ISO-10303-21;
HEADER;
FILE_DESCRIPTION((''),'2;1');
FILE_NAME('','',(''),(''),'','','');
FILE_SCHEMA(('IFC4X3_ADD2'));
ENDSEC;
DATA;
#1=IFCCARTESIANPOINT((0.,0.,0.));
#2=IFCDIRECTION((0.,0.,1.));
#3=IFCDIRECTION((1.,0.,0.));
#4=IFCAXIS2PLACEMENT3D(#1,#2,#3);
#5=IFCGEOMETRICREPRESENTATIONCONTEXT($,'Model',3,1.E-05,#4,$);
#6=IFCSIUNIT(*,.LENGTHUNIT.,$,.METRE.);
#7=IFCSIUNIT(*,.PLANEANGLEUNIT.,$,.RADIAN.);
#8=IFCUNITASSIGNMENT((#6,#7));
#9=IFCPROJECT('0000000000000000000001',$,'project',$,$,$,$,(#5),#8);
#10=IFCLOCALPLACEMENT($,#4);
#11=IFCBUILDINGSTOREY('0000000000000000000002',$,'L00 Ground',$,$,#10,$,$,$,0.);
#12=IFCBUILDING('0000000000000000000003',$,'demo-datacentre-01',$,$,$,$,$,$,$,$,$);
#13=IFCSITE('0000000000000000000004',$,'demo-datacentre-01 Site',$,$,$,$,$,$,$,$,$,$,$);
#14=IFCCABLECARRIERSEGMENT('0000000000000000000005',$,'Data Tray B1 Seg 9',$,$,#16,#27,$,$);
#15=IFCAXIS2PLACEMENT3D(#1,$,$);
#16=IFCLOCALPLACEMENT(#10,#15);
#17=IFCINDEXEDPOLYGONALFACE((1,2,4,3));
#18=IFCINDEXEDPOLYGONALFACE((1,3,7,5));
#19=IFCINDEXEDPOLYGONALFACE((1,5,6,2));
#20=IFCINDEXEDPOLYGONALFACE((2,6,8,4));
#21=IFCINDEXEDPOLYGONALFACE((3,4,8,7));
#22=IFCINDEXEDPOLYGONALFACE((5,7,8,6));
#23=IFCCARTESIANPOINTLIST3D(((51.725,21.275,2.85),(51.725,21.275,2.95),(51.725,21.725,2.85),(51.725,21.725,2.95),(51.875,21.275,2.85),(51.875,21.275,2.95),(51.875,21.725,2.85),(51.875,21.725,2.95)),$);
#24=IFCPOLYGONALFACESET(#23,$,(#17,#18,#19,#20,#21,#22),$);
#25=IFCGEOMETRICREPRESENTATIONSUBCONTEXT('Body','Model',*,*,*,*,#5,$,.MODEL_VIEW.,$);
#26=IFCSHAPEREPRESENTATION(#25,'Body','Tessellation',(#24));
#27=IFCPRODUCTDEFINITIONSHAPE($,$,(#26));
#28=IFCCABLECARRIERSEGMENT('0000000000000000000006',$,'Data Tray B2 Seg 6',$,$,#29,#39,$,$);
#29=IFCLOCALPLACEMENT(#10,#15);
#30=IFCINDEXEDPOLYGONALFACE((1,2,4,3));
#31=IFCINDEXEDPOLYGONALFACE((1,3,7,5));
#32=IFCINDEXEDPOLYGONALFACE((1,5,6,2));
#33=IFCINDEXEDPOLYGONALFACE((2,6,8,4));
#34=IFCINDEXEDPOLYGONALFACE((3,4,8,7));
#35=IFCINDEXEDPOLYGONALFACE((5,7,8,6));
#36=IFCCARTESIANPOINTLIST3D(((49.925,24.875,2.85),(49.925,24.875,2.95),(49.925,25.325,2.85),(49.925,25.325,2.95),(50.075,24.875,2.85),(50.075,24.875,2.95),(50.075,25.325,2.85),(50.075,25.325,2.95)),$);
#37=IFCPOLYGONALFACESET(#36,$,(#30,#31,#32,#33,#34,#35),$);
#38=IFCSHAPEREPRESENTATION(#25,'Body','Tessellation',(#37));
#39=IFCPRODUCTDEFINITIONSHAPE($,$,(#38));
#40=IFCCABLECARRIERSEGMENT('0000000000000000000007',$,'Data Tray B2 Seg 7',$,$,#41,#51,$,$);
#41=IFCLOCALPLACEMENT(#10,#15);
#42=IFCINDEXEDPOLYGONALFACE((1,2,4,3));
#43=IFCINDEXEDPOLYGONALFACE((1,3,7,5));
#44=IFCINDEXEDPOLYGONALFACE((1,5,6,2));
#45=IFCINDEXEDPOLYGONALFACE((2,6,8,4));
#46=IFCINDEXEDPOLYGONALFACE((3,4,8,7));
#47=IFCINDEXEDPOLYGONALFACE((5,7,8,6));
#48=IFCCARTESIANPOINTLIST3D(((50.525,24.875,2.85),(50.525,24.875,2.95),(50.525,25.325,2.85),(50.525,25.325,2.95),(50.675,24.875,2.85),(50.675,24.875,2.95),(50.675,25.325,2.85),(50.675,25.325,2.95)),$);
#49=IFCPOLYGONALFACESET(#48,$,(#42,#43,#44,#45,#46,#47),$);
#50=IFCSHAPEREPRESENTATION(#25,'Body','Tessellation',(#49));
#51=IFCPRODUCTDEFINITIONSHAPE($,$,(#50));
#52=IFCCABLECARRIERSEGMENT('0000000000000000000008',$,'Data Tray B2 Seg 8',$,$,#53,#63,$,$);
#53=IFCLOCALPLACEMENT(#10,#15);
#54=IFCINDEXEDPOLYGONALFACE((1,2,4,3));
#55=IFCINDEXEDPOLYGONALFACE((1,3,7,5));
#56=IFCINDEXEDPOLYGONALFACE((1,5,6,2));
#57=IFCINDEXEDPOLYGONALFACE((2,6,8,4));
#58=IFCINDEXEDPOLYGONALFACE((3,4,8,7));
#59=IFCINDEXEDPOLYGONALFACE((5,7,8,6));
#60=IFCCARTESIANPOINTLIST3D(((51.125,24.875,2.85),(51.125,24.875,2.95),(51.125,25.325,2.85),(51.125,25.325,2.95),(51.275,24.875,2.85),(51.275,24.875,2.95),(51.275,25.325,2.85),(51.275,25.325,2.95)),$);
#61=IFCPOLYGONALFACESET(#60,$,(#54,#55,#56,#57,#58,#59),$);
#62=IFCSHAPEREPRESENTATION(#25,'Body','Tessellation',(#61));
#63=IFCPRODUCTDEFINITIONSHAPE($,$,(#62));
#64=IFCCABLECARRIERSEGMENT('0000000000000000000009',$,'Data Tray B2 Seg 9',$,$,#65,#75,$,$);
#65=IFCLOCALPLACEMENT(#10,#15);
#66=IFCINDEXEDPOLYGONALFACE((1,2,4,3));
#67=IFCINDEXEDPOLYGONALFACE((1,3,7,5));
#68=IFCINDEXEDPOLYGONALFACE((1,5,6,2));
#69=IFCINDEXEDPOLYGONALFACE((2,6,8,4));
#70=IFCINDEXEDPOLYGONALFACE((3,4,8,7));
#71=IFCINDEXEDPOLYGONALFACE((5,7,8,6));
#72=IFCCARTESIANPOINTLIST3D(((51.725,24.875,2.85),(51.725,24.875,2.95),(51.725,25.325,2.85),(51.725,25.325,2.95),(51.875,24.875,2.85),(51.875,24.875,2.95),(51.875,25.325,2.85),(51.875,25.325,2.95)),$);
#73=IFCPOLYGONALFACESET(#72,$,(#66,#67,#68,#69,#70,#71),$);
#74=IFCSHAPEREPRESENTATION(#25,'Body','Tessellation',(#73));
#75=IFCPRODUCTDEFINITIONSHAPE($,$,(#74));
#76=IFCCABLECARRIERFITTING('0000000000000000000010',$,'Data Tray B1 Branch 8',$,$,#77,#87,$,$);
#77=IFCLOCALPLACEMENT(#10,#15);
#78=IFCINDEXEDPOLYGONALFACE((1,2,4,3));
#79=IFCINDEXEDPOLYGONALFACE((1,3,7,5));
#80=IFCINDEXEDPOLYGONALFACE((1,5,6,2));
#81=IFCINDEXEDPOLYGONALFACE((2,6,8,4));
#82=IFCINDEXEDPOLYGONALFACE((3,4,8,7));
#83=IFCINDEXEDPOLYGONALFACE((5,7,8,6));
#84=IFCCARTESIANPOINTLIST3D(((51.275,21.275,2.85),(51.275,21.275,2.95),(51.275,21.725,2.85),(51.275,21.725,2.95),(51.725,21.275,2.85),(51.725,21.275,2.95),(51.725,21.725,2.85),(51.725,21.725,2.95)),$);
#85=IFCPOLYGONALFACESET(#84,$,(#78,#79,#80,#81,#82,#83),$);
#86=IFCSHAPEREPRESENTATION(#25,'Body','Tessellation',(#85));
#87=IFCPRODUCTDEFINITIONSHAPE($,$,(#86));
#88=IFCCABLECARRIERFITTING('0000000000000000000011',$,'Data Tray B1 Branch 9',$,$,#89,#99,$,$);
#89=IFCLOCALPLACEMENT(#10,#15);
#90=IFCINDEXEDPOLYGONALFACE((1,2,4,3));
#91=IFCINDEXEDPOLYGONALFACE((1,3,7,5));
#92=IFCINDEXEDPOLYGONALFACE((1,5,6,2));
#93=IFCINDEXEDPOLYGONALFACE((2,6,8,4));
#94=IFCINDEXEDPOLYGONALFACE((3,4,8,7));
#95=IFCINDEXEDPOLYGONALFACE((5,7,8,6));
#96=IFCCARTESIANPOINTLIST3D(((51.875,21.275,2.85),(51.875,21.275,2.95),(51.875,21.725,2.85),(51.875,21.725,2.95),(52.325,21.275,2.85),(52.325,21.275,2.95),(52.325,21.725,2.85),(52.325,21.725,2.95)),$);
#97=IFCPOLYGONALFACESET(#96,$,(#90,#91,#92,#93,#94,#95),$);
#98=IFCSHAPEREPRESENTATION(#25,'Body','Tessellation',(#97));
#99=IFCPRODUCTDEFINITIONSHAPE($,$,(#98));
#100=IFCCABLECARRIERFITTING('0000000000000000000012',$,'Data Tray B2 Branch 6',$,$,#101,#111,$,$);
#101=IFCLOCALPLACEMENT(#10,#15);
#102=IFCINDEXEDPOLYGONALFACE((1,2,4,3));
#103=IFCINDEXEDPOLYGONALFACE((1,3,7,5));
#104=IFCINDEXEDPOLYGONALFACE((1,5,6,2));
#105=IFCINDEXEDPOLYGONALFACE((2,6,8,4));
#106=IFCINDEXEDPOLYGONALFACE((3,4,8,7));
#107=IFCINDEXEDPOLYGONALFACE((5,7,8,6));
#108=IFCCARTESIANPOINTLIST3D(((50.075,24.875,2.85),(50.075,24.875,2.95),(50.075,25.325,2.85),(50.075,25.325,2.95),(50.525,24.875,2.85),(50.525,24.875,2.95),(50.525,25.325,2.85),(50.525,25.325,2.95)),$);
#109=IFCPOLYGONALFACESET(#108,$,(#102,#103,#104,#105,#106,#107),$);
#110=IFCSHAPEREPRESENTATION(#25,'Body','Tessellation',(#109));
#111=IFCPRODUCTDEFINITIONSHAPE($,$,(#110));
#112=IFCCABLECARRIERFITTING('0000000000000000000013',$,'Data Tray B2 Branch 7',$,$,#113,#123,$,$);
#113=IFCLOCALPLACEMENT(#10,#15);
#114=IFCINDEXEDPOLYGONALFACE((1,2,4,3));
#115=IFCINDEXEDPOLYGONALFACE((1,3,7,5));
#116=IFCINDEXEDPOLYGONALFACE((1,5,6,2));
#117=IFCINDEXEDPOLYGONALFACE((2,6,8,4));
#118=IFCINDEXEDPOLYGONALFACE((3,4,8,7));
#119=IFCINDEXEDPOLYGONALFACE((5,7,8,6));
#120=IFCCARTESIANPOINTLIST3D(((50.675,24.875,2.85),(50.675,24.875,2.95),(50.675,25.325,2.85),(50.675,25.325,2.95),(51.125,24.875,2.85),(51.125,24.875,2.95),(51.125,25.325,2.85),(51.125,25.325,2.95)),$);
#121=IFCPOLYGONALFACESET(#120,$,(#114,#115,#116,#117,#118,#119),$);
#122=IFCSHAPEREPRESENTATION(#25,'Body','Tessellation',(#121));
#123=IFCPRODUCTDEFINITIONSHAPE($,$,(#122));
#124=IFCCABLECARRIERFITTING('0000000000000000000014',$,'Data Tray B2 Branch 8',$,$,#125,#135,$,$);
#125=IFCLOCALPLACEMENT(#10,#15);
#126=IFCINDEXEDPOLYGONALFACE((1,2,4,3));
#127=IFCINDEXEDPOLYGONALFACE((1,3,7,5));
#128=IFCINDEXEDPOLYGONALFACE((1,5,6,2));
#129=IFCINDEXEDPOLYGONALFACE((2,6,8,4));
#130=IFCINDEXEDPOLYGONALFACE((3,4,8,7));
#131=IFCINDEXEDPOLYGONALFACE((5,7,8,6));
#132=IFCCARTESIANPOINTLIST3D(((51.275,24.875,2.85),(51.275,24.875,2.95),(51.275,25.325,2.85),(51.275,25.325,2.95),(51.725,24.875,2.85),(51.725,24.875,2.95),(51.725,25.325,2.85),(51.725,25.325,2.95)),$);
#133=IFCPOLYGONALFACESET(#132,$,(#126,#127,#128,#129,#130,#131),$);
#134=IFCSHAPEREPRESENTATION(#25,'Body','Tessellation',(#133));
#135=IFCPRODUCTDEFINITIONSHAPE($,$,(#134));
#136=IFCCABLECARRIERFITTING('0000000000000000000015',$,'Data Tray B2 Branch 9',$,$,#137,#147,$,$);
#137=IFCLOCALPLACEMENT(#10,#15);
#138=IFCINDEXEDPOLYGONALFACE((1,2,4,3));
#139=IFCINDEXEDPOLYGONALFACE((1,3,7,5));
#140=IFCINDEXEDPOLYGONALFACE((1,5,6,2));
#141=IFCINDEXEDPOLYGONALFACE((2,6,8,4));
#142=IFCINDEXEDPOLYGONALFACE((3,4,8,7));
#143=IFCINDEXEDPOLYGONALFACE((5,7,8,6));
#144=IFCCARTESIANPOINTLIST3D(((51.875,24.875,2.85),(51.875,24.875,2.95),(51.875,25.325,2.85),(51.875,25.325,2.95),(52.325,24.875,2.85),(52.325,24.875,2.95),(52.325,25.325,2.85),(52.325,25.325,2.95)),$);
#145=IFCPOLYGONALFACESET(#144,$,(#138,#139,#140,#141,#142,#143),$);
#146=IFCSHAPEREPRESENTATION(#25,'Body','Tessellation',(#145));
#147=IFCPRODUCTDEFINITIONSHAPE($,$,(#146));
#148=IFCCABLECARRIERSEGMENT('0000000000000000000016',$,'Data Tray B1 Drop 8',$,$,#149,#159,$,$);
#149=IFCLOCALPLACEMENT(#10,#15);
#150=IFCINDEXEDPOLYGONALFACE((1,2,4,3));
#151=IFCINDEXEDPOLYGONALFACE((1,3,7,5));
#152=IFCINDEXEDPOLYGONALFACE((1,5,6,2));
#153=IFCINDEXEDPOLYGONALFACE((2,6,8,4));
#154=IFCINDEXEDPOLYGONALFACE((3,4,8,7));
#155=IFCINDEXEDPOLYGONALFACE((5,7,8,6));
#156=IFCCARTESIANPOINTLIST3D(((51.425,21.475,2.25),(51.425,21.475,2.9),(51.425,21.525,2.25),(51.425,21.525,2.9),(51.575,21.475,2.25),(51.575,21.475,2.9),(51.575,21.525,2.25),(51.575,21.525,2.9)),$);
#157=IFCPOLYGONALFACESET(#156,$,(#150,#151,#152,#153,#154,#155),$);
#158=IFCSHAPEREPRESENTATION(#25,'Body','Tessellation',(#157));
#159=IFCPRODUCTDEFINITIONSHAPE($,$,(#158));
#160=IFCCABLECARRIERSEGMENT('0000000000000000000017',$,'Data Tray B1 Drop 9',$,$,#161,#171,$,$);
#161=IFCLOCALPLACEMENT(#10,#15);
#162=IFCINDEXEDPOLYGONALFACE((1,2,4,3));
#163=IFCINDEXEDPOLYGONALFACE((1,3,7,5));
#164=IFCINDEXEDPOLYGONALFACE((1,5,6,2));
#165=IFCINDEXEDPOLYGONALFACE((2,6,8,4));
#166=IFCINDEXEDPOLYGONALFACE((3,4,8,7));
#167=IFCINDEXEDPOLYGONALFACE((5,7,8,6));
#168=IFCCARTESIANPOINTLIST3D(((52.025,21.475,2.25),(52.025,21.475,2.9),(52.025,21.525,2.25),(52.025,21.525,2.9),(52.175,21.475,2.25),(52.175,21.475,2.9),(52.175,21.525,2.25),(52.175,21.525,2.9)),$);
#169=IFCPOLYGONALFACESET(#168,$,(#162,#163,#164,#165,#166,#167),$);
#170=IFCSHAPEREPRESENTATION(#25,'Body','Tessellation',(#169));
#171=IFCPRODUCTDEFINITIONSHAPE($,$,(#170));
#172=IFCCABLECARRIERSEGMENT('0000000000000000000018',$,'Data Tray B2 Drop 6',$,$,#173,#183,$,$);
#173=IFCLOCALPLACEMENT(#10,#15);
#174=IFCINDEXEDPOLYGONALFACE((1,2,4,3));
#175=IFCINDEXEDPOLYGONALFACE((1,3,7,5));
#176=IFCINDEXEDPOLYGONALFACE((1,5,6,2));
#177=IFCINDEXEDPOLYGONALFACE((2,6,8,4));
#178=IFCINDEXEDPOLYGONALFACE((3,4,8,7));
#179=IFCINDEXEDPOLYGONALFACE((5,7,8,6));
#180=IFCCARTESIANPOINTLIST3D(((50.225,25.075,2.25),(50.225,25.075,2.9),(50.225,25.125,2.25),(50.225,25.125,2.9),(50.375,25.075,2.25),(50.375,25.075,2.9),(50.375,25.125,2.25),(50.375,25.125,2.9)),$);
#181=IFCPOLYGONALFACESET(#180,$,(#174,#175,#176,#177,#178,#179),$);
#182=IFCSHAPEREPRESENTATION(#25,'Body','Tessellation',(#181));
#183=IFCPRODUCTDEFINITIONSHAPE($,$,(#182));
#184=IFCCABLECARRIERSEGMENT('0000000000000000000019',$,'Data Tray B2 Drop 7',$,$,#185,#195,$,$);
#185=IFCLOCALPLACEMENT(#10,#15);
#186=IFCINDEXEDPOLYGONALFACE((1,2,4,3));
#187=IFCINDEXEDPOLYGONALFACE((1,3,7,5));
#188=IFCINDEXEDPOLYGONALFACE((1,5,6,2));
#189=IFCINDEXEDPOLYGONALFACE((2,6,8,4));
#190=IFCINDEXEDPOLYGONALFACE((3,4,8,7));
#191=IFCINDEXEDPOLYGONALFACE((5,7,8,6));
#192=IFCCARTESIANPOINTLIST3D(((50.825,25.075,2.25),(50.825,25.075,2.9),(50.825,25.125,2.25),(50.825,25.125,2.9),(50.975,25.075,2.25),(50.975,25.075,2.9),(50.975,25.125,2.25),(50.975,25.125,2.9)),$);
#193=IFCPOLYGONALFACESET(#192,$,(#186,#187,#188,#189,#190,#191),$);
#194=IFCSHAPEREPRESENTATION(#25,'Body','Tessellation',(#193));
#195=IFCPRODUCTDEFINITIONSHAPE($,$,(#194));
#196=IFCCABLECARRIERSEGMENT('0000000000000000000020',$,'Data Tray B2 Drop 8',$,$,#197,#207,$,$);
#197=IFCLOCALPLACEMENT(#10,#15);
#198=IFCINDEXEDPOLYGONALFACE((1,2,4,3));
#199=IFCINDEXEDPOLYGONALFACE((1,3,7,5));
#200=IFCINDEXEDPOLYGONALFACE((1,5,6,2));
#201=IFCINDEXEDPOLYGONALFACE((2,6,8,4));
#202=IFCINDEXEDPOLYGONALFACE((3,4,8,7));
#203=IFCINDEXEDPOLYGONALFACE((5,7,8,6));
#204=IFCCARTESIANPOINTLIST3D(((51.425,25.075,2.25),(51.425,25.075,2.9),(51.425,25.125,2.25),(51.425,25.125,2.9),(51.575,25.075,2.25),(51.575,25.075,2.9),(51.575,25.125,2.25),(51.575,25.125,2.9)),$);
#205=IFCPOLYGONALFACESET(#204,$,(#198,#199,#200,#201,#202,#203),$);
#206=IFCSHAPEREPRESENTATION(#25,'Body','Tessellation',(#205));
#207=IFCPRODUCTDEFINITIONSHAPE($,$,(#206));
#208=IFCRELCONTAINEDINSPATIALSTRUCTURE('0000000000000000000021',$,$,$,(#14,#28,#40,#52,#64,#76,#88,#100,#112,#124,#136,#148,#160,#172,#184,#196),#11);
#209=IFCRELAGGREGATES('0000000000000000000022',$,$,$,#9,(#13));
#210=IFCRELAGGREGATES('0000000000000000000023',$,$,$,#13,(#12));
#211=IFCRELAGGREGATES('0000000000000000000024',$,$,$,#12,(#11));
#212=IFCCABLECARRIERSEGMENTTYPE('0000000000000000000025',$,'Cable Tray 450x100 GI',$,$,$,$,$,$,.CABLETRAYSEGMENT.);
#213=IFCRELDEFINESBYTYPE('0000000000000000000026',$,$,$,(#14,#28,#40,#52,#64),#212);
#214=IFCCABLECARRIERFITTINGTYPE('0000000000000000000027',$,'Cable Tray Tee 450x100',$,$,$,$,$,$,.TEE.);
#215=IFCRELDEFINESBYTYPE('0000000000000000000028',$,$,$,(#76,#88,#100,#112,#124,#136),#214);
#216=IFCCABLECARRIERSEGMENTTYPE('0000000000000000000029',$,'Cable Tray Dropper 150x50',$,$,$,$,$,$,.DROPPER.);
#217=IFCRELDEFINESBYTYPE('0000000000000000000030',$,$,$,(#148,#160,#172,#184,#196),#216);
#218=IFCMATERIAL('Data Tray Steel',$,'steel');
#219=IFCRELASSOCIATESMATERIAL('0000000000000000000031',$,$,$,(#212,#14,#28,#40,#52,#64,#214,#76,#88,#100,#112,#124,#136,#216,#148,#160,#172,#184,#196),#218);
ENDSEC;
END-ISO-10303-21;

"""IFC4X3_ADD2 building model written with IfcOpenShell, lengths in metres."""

from ifc_helpers import new_model, si_unit, frame, origin_with_axes, place, context, subcontext, project, spatial, rectangle, extrude, material, type_object, element, save


model = new_model("IFC4X3_ADD2")

# Units and contexts
model_context = context("Model", 3, precision=1e-05, world=origin_with_axes())
body_context = subcontext(model_context, "Body", "Model", "MODEL_VIEW")
ifc_project = project(units=[si_unit("LENGTHUNIT", "METRE"), si_unit("PLANEANGLEUNIT", "RADIAN")], contexts=[model_context])

# Site, building, storey
site = spatial("IfcSite", under=ifc_project, Name="demo-datacentre-01 Site")
building = spatial("IfcBuilding", under=site, Name="demo-datacentre-01")
storey_placement = place(None, origin_with_axes())
storey = spatial("IfcBuildingStorey", under=building, at=storey_placement, Name="L00 Ground", Elevation=0.0)

# Cable carrier segments
ifc_material_1 = material(Name="Data Tray Steel", Category="steel")
cable_carrier_segment_type_1 = type_object("IfcCableCarrierSegmentType", Name="Cable Tray 450x100 GI", PredefinedType="CABLETRAYSEGMENT", material=ifc_material_1)
cable_carrier_segment_1_placement = place(storey_placement, frame((51.725, 21.5, 2.9), z_axis=(1.0, 0.0, 0.0), x_axis=(0.0, 1.0, 0.0)))
element("IfcCableCarrierSegment", 1, at=cable_carrier_segment_1_placement, inside=storey, type_object=cable_carrier_segment_type_1, material=ifc_material_1, Name="Data Tray B1 Seg 9", context=body_context, shape_type="SweptSolid", body=[
    extrude(rectangle(XDim=0.45, YDim=0.1), origin_with_axes(), (0.0, 0.0, 1.0), 0.15),
])
for number, where, z_axis, x_axis, name in (
    (2, (49.925, 25.1, 2.9), (1.0, 0.0, 0.0), (0.0, 1.0, 0.0), "Data Tray B2 Seg 6"),
    (3, (50.525, 25.1, 2.9), (1.0, 0.0, 0.0), (0.0, 1.0, 0.0), "Data Tray B2 Seg 7"),
    (4, (51.125, 25.1, 2.9), (1.0, 0.0, 0.0), (0.0, 1.0, 0.0), "Data Tray B2 Seg 8"),
):
    element("IfcCableCarrierSegment", number, at=place(storey_placement, frame(where, z_axis=z_axis, x_axis=x_axis)), inside=storey, type_object=cable_carrier_segment_type_1, material=ifc_material_1, Name=name, context=body_context, shape_type="SweptSolid", body=[
        extrude(rectangle(XDim=0.45, YDim=0.1), origin_with_axes(), (0.0, 0.0, 1.0), 0.15),
    ])
cable_carrier_segment_2_placement = place(storey_placement, frame((51.725, 25.1, 2.9), z_axis=(1.0, 0.0, 0.0), x_axis=(0.0, 1.0, 0.0)))
element("IfcCableCarrierSegment", 5, at=cable_carrier_segment_2_placement, inside=storey, type_object=cable_carrier_segment_type_1, material=ifc_material_1, Name="Data Tray B2 Seg 9", context=body_context, shape_type="SweptSolid", body=[
    extrude(rectangle(XDim=0.45, YDim=0.1), origin_with_axes(), (0.0, 0.0, 1.0), 0.15),
])

# Cable carrier fittings
cable_carrier_fitting_type = type_object("IfcCableCarrierFittingType", Name="Cable Tray Tee 450x100", PredefinedType="TEE", material=ifc_material_1)
for number, where, z_axis, x_axis, name in (
    (6, (51.5, 21.5, 2.85), (0.0, 0.0, 1.0), (1.0, 0.0, 0.0), "Data Tray B1 Branch 8"),
    (7, (52.1, 21.5, 2.85), (0.0, 0.0, 1.0), (1.0, 0.0, 0.0), "Data Tray B1 Branch 9"),
    (8, (50.3, 25.1, 2.85), (0.0, 0.0, 1.0), (1.0, 0.0, 0.0), "Data Tray B2 Branch 6"),
    (9, (50.9, 25.1, 2.85), (0.0, 0.0, 1.0), (1.0, 0.0, 0.0), "Data Tray B2 Branch 7"),
    (10, (51.5, 25.1, 2.85), (0.0, 0.0, 1.0), (1.0, 0.0, 0.0), "Data Tray B2 Branch 8"),
    (11, (52.1, 25.1, 2.85), (0.0, 0.0, 1.0), (1.0, 0.0, 0.0), "Data Tray B2 Branch 9"),
):
    element("IfcCableCarrierFitting", number, at=place(storey_placement, frame(where, z_axis=z_axis, x_axis=x_axis)), inside=storey, type_object=cable_carrier_fitting_type, material=ifc_material_1, Name=name, context=body_context, shape_type="SweptSolid", body=[
        extrude(rectangle(XDim=0.45, YDim=0.45), origin_with_axes(), (0.0, 0.0, 1.0), 0.1),
    ])

# Cable carrier segments
cable_carrier_segment_type_2 = type_object("IfcCableCarrierSegmentType", Name="Cable Tray Dropper 150x50", PredefinedType="DROPPER", material=ifc_material_1)
for number, where, z_axis, x_axis, name in (
    (12, (51.5, 21.5, 2.9), (0.0, 0.0, -1.0), (1.0, 0.0, 0.0), "Data Tray B1 Drop 8"),
    (13, (52.1, 21.5, 2.9), (0.0, 0.0, -1.0), (1.0, 0.0, 0.0), "Data Tray B1 Drop 9"),
    (14, (50.3, 25.1, 2.9), (0.0, 0.0, -1.0), (1.0, 0.0, 0.0), "Data Tray B2 Drop 6"),
    (15, (50.9, 25.1, 2.9), (0.0, 0.0, -1.0), (1.0, 0.0, 0.0), "Data Tray B2 Drop 7"),
    (16, (51.5, 25.1, 2.9), (0.0, 0.0, -1.0), (1.0, 0.0, 0.0), "Data Tray B2 Drop 8"),
):
    element("IfcCableCarrierSegment", number, at=place(storey_placement, frame(where, z_axis=z_axis, x_axis=x_axis)), inside=storey, type_object=cable_carrier_segment_type_2, material=ifc_material_1, Name=name, context=body_context, shape_type="SweptSolid", body=[
        extrude(rectangle(XDim=0.15, YDim=0.05), origin_with_axes(), (0.0, 0.0, 1.0), 0.65),
    ])

save(model, "model.ifc")
